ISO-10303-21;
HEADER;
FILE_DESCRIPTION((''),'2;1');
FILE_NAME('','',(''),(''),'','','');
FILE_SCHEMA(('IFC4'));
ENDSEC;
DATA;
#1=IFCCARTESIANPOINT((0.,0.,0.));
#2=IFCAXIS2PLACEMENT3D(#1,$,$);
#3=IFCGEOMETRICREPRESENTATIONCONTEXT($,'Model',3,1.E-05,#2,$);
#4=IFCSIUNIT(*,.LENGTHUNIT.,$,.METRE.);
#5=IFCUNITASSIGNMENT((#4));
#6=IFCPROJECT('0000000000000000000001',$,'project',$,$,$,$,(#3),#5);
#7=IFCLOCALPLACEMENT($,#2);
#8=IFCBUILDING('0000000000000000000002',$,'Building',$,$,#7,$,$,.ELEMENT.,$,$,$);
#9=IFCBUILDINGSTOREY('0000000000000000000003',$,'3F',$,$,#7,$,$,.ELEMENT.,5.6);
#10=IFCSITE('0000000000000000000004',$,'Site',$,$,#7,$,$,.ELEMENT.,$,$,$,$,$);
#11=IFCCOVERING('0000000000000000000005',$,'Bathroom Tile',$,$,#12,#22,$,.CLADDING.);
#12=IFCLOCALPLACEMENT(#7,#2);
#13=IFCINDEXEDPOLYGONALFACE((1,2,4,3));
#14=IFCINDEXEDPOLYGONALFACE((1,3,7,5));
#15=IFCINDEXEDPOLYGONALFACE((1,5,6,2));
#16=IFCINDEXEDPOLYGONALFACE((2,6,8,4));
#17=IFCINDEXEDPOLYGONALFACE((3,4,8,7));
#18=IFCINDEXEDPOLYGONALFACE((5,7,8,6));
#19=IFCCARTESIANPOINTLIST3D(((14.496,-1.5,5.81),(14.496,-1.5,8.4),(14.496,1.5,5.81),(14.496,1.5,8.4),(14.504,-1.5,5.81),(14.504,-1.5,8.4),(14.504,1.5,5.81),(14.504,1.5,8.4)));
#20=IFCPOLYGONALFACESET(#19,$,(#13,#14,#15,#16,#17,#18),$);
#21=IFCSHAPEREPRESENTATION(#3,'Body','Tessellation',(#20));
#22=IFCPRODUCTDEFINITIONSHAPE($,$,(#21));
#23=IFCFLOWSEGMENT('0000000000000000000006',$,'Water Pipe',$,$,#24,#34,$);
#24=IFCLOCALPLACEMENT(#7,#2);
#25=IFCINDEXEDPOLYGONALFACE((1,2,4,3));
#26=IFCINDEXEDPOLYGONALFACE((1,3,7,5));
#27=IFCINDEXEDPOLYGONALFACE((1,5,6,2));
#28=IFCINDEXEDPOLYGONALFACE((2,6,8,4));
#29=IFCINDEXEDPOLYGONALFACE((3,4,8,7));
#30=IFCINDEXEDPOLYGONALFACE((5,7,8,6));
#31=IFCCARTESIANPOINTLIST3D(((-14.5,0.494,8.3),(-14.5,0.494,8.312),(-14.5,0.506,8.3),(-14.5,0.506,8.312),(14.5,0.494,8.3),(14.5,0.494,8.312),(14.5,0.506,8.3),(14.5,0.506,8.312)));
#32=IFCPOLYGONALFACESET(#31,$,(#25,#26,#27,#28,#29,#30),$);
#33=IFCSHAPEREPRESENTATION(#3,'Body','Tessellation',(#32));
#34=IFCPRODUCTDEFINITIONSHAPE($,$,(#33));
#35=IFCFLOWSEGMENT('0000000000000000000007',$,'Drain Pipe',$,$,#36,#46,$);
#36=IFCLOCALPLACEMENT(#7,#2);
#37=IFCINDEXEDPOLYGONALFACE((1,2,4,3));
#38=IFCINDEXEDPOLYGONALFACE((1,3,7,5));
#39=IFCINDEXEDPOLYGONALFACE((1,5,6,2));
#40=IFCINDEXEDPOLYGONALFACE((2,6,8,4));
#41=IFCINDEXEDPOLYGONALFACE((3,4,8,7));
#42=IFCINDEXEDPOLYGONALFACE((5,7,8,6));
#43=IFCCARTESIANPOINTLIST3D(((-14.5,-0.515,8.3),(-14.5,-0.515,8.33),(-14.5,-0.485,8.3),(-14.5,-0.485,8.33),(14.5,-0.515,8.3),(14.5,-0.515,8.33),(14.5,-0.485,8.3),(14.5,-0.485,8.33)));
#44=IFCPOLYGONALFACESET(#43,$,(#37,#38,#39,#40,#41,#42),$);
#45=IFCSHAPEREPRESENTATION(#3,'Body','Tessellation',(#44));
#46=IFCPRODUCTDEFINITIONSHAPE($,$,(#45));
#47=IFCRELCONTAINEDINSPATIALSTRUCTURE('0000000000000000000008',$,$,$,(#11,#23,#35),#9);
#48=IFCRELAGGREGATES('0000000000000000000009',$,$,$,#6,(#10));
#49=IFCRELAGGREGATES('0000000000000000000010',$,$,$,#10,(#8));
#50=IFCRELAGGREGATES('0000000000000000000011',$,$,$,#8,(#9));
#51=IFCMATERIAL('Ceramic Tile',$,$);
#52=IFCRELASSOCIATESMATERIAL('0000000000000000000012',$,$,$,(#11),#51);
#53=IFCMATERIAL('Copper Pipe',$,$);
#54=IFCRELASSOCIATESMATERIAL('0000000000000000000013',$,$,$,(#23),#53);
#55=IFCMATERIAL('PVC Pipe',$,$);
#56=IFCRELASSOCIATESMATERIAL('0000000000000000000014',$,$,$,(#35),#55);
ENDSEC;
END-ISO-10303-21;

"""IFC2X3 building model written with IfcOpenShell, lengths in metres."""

from ifc_helpers import new_model, si_unit, frame, origin, origin_2d, place, context, project, spatial, rectangle, extrude, material, element, save


model = new_model("IFC2X3")

# Units and contexts
model_context = context("Model", 3, precision=1e-05, world=origin())
ifc_project = project(units=[si_unit("LENGTHUNIT", "METRE")], contexts=[model_context])

# Site, building, storey
placement = place(None, origin())
site = spatial("IfcSite", under=ifc_project, at=placement, Name="Site", CompositionType="ELEMENT")
building = spatial("IfcBuilding", under=site, at=placement, Name="Building", CompositionType="ELEMENT")
storey = spatial("IfcBuildingStorey", under=building, at=placement, Name="3F", CompositionType="ELEMENT", Elevation=5.6)

# Covering
ifc_material_1 = material(Name="Ceramic Tile")
covering_1_placement = place(None, frame((14.5, 0.0, 5.81)))
element("IfcCovering", 1, at=covering_1_placement, inside=storey, material=ifc_material_1, Name="Bathroom Tile", PredefinedType="CLADDING", context=model_context, shape_type="SweptSolid", body=[
    extrude(rectangle(XDim=0.008, YDim=3.0, at=origin_2d()), origin(), (0.0, 0.0, 1.0), 2.59),
])

# Flow segments
ifc_material_2 = material(Name="Copper Pipe")
flow_segment_1_placement = place(None, frame((0.0, 0.5, 8.3)))
element("IfcFlowSegment", 2, at=flow_segment_1_placement, inside=storey, material=ifc_material_2, Name="Water Pipe", context=model_context, shape_type="SweptSolid", body=[
    extrude(rectangle(XDim=29.0, YDim=0.012, at=origin_2d()), origin(), (0.0, 0.0, 1.0), 0.012),
])
ifc_material_3 = material(Name="PVC Pipe")
flow_segment_2_placement = place(None, frame((0.0, -0.5, 8.3)))
element("IfcFlowSegment", 3, at=flow_segment_2_placement, inside=storey, material=ifc_material_3, Name="Drain Pipe", context=model_context, shape_type="SweptSolid", body=[
    extrude(rectangle(XDim=29.0, YDim=0.03, at=origin_2d()), origin(), (0.0, 0.0, 1.0), 0.03),
])

save(model, "model.ifc")
